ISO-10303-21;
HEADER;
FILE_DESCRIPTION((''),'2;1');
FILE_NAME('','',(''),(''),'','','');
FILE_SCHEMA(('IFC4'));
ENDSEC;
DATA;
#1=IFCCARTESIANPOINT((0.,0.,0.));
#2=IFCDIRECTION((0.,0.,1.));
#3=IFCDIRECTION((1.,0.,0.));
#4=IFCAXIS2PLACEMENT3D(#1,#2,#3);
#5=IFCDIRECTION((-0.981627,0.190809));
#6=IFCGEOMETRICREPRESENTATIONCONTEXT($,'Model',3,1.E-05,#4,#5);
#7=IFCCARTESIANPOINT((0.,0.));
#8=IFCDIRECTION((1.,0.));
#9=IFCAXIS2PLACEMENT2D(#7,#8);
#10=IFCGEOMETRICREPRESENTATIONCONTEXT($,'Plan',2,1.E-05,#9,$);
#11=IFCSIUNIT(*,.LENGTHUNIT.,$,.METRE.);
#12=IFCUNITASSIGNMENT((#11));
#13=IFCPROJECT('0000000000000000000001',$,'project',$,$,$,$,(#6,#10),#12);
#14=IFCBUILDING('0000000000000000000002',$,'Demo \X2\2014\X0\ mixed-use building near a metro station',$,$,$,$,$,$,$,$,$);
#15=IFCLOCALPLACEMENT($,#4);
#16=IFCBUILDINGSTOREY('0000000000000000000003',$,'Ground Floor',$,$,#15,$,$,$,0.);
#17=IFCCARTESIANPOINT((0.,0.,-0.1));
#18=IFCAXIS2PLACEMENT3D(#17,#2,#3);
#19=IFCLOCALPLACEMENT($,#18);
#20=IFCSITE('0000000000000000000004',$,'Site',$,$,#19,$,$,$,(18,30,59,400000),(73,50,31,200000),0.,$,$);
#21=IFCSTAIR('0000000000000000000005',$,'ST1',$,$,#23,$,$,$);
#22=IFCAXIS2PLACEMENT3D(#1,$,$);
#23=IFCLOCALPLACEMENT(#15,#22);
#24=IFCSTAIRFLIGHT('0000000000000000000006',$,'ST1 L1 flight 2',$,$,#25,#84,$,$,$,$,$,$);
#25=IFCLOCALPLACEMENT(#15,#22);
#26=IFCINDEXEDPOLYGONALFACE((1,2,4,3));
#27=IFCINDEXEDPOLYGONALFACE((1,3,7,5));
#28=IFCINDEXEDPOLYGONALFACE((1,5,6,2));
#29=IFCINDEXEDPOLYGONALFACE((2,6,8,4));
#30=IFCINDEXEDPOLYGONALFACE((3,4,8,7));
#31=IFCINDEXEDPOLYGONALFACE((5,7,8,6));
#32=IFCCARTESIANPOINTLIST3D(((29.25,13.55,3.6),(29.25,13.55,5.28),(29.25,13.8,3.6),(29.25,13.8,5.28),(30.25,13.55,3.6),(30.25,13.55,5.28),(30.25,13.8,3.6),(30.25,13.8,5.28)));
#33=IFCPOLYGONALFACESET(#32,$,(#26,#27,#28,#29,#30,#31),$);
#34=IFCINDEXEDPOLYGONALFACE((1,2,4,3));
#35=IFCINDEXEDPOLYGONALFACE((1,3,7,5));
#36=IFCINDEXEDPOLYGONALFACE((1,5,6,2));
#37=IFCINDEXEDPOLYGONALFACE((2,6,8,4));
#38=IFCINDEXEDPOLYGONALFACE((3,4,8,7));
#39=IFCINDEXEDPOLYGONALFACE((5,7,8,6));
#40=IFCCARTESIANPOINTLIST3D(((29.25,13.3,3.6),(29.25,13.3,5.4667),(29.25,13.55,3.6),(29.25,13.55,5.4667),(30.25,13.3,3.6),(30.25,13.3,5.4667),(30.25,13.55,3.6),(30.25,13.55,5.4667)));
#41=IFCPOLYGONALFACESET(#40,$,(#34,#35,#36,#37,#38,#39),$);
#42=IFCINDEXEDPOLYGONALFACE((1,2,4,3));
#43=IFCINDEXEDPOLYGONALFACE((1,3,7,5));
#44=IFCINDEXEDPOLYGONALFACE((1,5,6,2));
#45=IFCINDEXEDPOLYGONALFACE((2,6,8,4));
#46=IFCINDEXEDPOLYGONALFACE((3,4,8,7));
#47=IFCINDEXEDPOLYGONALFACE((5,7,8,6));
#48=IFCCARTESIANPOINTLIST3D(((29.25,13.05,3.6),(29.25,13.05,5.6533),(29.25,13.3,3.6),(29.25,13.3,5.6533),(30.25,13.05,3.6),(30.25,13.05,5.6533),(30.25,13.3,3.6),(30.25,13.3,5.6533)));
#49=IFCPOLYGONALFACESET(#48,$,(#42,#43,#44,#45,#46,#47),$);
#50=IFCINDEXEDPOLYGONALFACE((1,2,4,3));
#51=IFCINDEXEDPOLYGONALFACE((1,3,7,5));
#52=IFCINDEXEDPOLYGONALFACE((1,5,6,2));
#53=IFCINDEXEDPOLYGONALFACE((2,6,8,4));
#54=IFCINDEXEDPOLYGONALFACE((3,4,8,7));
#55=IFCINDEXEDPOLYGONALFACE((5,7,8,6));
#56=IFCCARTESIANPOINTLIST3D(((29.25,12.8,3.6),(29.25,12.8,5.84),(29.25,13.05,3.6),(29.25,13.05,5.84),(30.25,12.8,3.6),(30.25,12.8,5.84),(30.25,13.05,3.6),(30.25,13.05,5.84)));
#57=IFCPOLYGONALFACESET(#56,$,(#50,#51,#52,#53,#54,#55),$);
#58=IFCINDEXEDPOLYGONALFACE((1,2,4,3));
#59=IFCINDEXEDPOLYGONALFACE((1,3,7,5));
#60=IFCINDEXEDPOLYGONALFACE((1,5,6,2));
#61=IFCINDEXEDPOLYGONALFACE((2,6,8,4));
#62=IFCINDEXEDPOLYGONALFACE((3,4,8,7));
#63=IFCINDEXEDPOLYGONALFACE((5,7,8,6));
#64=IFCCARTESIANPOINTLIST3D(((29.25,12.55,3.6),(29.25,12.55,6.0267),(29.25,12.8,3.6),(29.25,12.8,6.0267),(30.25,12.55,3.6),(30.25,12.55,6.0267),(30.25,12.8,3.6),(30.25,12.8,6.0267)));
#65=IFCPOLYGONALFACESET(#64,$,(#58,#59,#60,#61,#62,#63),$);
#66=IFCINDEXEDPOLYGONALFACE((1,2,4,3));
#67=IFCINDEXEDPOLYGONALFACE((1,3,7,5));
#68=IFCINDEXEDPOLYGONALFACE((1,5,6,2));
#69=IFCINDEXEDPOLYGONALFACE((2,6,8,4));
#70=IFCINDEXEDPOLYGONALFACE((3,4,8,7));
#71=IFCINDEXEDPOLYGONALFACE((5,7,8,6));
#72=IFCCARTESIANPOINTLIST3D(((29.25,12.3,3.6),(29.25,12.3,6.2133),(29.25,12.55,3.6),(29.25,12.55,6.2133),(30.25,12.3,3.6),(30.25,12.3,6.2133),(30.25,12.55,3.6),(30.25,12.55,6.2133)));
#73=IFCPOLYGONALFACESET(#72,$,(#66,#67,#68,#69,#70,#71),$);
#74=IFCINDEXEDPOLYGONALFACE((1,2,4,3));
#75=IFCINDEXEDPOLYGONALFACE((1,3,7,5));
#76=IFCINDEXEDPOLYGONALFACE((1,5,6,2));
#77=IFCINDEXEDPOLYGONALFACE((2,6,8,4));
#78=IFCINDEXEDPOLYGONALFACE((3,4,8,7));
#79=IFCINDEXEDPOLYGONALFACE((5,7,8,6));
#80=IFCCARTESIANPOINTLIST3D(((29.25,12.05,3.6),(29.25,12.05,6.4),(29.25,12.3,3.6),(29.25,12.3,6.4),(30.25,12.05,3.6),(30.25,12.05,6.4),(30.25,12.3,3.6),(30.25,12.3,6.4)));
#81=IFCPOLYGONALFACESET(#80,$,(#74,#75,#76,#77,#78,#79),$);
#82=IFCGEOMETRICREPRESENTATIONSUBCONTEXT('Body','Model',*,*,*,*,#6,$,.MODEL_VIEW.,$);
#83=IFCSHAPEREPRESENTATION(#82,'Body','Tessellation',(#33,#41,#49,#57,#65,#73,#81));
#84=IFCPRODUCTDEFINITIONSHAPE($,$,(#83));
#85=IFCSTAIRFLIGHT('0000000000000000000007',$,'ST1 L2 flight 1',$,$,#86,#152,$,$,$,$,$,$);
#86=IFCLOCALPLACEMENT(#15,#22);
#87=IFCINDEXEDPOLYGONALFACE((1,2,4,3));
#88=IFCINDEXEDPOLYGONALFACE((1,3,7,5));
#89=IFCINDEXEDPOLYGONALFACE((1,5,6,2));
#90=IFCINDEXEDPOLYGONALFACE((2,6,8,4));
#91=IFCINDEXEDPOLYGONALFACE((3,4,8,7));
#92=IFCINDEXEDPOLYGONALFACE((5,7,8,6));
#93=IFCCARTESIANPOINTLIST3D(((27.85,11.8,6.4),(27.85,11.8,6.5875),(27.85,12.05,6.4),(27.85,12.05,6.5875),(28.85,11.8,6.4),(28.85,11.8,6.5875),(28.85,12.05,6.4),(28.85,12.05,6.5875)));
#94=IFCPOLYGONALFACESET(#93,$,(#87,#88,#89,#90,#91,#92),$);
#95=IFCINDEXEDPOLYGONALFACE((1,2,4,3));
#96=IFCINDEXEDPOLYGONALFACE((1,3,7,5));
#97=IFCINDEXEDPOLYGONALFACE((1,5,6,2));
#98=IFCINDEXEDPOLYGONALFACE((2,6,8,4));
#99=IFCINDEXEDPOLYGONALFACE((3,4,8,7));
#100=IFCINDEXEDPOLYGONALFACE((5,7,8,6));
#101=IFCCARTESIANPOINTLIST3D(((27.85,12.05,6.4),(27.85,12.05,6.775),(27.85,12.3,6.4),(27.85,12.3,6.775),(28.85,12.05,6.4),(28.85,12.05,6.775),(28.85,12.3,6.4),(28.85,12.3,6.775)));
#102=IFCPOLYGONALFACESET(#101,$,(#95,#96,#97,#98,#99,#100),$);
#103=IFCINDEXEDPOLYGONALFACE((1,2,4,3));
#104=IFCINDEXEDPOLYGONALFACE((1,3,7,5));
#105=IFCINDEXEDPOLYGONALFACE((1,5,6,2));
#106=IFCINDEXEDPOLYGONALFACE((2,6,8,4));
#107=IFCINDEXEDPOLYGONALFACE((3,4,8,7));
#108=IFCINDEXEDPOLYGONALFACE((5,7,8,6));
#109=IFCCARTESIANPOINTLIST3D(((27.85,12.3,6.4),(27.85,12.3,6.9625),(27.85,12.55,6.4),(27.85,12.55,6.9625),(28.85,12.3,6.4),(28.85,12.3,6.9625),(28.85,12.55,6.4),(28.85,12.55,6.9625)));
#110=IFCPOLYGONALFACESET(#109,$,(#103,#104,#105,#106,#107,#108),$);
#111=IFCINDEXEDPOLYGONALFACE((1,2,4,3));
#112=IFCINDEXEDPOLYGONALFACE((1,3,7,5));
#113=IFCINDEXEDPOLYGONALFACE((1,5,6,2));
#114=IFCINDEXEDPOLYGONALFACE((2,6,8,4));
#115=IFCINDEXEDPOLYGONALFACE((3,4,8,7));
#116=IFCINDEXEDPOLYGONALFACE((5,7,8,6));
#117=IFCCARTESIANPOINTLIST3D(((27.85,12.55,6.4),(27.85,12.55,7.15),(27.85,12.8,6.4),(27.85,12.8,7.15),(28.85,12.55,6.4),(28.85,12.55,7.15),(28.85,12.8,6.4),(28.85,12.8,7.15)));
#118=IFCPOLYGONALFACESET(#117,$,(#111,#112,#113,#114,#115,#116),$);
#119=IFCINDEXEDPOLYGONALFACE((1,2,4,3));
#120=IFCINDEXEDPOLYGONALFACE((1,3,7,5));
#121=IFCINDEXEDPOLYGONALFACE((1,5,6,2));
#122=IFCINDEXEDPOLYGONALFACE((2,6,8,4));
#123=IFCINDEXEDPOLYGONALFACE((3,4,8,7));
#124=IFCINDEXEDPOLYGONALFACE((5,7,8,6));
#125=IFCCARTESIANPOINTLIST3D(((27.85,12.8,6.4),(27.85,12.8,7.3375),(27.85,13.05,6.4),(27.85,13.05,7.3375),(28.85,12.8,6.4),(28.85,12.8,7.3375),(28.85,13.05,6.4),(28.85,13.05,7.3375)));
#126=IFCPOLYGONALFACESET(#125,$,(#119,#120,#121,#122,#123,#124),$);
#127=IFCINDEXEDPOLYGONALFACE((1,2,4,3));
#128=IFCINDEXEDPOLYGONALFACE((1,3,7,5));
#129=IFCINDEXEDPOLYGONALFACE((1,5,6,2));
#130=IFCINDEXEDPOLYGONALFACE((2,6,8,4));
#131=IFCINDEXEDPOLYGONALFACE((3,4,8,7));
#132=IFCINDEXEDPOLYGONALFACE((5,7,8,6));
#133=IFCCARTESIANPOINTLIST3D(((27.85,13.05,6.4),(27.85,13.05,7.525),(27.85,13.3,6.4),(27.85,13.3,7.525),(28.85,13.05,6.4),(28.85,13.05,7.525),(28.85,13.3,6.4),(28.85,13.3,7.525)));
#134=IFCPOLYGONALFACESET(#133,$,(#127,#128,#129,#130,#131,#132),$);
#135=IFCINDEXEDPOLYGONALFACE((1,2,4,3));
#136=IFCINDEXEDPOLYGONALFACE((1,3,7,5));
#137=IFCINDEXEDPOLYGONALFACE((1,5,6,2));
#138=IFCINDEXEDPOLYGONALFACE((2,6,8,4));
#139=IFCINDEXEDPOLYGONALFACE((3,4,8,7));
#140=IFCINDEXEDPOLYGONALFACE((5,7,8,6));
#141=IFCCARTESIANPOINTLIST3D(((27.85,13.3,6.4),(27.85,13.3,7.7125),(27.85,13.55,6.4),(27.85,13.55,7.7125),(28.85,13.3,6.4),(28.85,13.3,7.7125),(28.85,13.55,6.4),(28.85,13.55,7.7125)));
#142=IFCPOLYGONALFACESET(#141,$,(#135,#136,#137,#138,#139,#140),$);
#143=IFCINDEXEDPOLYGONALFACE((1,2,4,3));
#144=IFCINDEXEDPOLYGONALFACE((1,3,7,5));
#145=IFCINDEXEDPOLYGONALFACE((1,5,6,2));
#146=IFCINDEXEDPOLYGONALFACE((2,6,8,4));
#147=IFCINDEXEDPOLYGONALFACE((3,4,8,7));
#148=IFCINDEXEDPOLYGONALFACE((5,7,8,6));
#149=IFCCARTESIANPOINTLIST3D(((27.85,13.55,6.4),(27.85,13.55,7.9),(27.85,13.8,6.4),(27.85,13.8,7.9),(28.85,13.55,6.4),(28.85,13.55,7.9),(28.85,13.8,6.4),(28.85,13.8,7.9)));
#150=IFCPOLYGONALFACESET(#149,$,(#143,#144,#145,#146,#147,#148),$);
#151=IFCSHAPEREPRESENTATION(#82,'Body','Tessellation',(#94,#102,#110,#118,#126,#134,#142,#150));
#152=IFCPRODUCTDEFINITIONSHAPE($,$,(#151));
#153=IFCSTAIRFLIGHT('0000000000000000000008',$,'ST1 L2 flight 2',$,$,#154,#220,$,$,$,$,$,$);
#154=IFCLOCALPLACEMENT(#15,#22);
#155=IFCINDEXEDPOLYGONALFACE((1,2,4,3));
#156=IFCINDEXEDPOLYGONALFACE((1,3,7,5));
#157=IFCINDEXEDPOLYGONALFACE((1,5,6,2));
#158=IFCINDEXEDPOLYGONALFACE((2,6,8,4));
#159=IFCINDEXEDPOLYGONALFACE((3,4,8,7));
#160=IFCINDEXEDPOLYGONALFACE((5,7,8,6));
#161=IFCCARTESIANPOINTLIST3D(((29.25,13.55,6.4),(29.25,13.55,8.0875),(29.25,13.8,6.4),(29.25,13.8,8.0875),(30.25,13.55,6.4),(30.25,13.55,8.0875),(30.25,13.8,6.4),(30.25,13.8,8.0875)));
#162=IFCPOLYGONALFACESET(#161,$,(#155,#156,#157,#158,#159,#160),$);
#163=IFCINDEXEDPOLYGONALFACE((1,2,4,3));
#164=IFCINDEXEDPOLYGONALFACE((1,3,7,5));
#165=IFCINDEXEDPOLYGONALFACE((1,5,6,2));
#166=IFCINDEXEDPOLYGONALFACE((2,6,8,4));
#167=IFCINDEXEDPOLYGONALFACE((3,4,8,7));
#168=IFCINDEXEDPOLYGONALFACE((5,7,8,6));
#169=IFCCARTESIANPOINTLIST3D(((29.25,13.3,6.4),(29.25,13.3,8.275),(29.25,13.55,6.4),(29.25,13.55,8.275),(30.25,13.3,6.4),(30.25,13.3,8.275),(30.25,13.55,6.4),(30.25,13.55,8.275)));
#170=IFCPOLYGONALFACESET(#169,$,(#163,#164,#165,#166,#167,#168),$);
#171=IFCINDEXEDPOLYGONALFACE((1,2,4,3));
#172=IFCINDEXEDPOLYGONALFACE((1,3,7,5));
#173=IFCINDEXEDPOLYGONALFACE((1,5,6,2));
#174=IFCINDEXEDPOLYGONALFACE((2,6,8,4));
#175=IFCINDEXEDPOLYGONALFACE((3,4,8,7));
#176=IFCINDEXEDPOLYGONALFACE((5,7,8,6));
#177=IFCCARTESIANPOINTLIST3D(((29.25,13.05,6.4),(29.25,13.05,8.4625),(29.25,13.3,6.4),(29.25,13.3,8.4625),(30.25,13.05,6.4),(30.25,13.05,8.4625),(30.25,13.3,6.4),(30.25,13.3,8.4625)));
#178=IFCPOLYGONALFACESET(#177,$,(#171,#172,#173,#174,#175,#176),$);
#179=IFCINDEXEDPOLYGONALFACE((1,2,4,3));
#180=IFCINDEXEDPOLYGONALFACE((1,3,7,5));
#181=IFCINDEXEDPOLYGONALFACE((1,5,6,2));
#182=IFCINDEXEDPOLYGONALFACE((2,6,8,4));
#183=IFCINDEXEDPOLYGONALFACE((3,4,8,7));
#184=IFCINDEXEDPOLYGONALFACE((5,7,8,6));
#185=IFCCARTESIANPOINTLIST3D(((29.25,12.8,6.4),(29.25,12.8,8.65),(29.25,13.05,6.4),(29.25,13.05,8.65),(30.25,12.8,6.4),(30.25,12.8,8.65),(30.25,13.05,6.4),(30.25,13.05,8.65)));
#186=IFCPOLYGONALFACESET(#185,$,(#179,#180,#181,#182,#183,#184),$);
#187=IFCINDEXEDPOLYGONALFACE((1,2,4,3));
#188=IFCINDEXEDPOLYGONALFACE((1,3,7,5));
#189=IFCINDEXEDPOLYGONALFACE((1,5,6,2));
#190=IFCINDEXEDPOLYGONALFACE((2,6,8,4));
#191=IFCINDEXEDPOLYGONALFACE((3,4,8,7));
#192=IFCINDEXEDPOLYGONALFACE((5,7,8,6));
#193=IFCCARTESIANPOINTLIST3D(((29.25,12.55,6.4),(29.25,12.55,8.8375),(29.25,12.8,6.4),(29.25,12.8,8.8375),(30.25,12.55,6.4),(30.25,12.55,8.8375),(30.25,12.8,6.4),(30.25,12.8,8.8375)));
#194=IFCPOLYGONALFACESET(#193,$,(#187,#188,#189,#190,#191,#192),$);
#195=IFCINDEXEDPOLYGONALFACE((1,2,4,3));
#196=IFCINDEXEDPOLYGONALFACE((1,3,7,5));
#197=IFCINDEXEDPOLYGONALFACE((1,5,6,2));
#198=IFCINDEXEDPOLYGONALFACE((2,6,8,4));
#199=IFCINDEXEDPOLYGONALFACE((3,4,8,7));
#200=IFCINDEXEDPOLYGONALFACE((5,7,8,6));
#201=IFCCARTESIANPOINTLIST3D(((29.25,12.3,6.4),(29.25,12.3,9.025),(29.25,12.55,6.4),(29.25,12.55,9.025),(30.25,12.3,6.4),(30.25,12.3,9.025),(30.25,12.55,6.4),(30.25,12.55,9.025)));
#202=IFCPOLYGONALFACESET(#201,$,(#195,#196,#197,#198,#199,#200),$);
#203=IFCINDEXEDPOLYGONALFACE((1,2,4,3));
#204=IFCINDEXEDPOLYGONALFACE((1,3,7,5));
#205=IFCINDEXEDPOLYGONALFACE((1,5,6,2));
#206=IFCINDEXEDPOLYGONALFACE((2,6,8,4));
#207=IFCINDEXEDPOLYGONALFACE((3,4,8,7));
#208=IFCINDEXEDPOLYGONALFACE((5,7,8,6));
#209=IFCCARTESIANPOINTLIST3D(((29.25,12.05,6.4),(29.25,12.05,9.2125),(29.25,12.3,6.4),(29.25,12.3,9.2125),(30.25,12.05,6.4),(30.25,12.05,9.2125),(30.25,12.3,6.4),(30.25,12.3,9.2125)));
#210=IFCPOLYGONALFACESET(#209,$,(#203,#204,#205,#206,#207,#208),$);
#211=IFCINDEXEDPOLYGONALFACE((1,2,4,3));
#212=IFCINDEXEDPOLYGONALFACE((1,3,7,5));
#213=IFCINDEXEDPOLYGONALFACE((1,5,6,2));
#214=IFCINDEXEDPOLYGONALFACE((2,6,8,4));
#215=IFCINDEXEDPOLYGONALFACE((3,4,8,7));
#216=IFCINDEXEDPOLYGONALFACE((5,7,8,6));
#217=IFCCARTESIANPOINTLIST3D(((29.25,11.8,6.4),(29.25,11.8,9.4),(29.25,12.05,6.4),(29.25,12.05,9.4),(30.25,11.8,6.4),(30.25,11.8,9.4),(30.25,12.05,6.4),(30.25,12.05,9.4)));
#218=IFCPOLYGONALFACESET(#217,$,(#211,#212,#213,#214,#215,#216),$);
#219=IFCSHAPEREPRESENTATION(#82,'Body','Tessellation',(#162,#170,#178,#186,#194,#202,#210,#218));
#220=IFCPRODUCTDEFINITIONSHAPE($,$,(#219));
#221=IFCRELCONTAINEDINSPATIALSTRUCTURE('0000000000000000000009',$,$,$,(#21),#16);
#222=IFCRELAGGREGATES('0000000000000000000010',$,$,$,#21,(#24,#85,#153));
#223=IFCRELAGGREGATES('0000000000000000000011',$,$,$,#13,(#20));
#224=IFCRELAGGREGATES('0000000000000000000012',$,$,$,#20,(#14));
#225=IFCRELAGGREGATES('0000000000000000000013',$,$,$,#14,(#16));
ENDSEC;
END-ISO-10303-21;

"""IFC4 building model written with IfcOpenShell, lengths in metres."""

from ifc_helpers import new_model, si_unit, direction, frame, origin_with_axes, origin_2d_with_axis, place, context, subcontext, project, spatial, line, indexed_curve, outline, extrude, element, aggregate, save


model = new_model("IFC4")

# Units and contexts
model_context = context("Model", 3, precision=1e-05, world=origin_with_axes(), true_north=direction((-0.981627, 0.190809)))
plan_context = context("Plan", 2, precision=1e-05, world=origin_2d_with_axis())
body_context = subcontext(model_context, "Body", "Model", "MODEL_VIEW")
ifc_project = project(units=[si_unit("LENGTHUNIT", "METRE")], contexts=[model_context, plan_context])

# Site, building, storey
site_placement = place(None, frame((0.0, 0.0, -0.1), z_axis=(0.0, 0.0, 1.0), x_axis=(1.0, 0.0, 0.0)))
site = spatial("IfcSite", under=ifc_project, at=site_placement, Name="Site", RefLatitude=(18, 30, 59, 400000), RefLongitude=(73, 50, 31, 200000), RefElevation=0.0)
building = spatial("IfcBuilding", under=site, Name="Demo — mixed-use building near a metro station")
storey_placement = place(None, origin_with_axes())
storey = spatial("IfcBuildingStorey", under=building, at=storey_placement, Name="Ground Floor", Elevation=0.0)

# Stair, stair flights
stair = element("IfcStair", 1, inside=storey, Name="ST1")
stair_flight_1_placement = place(None, origin_with_axes())
stair_flight_1 = element("IfcStairFlight", 2, at=stair_flight_1_placement, Name="ST1 L1 flight 2", context=body_context, shape_type="SweptSolid", body=[
    extrude(outline(indexed_curve([(29.25, 13.55), (30.25, 13.55), (30.25, 13.8), (29.25, 13.8)], segments=[line(1, 2, 3, 4, 1)])), frame((0.0, 0.0, 3.6), z_axis=(0.0, 0.0, 1.0), x_axis=(1.0, 0.0, 0.0)), (0.0, 0.0, 1.0), 1.68),
    extrude(outline(indexed_curve([(29.25, 13.3), (30.25, 13.3), (30.25, 13.55), (29.25, 13.55)], segments=[line(1, 2, 3, 4, 1)])), frame((0.0, 0.0, 3.6), z_axis=(0.0, 0.0, 1.0), x_axis=(1.0, 0.0, 0.0)), (0.0, 0.0, 1.0), 1.8667),
    extrude(outline(indexed_curve([(29.25, 13.05), (30.25, 13.05), (30.25, 13.3), (29.25, 13.3)], segments=[line(1, 2, 3, 4, 1)])), frame((0.0, 0.0, 3.6), z_axis=(0.0, 0.0, 1.0), x_axis=(1.0, 0.0, 0.0)), (0.0, 0.0, 1.0), 2.0533),
    extrude(outline(indexed_curve([(29.25, 12.8), (30.25, 12.8), (30.25, 13.05), (29.25, 13.05)], segments=[line(1, 2, 3, 4, 1)])), frame((0.0, 0.0, 3.6), z_axis=(0.0, 0.0, 1.0), x_axis=(1.0, 0.0, 0.0)), (0.0, 0.0, 1.0), 2.24),
    extrude(outline(indexed_curve([(29.25, 12.55), (30.25, 12.55), (30.25, 12.8), (29.25, 12.8)], segments=[line(1, 2, 3, 4, 1)])), frame((0.0, 0.0, 3.6), z_axis=(0.0, 0.0, 1.0), x_axis=(1.0, 0.0, 0.0)), (0.0, 0.0, 1.0), 2.4267),
    extrude(outline(indexed_curve([(29.25, 12.3), (30.25, 12.3), (30.25, 12.55), (29.25, 12.55)], segments=[line(1, 2, 3, 4, 1)])), frame((0.0, 0.0, 3.6), z_axis=(0.0, 0.0, 1.0), x_axis=(1.0, 0.0, 0.0)), (0.0, 0.0, 1.0), 2.6133),
    extrude(outline(indexed_curve([(29.25, 12.05), (30.25, 12.05), (30.25, 12.3), (29.25, 12.3)], segments=[line(1, 2, 3, 4, 1)])), frame((0.0, 0.0, 3.6), z_axis=(0.0, 0.0, 1.0), x_axis=(1.0, 0.0, 0.0)), (0.0, 0.0, 1.0), 2.8),
])
stair_flight_2_placement = place(None, origin_with_axes())
stair_flight_2 = element("IfcStairFlight", 3, at=stair_flight_2_placement, Name="ST1 L2 flight 1", context=body_context, shape_type="SweptSolid", body=[
    extrude(outline(indexed_curve([(27.85, 11.8), (28.85, 11.8), (28.85, 12.05), (27.85, 12.05)], segments=[line(1, 2, 3, 4, 1)])), frame((0.0, 0.0, 6.4), z_axis=(0.0, 0.0, 1.0), x_axis=(1.0, 0.0, 0.0)), (0.0, 0.0, 1.0), 0.1875),
    extrude(outline(indexed_curve([(27.85, 12.05), (28.85, 12.05), (28.85, 12.3), (27.85, 12.3)], segments=[line(1, 2, 3, 4, 1)])), frame((0.0, 0.0, 6.4), z_axis=(0.0, 0.0, 1.0), x_axis=(1.0, 0.0, 0.0)), (0.0, 0.0, 1.0), 0.375),
    extrude(outline(indexed_curve([(27.85, 12.3), (28.85, 12.3), (28.85, 12.55), (27.85, 12.55)], segments=[line(1, 2, 3, 4, 1)])), frame((0.0, 0.0, 6.4), z_axis=(0.0, 0.0, 1.0), x_axis=(1.0, 0.0, 0.0)), (0.0, 0.0, 1.0), 0.5625),
    extrude(outline(indexed_curve([(27.85, 12.55), (28.85, 12.55), (28.85, 12.8), (27.85, 12.8)], segments=[line(1, 2, 3, 4, 1)])), frame((0.0, 0.0, 6.4), z_axis=(0.0, 0.0, 1.0), x_axis=(1.0, 0.0, 0.0)), (0.0, 0.0, 1.0), 0.75),
    extrude(outline(indexed_curve([(27.85, 12.8), (28.85, 12.8), (28.85, 13.05), (27.85, 13.05)], segments=[line(1, 2, 3, 4, 1)])), frame((0.0, 0.0, 6.4), z_axis=(0.0, 0.0, 1.0), x_axis=(1.0, 0.0, 0.0)), (0.0, 0.0, 1.0), 0.9375),
    extrude(outline(indexed_curve([(27.85, 13.05), (28.85, 13.05), (28.85, 13.3), (27.85, 13.3)], segments=[line(1, 2, 3, 4, 1)])), frame((0.0, 0.0, 6.4), z_axis=(0.0, 0.0, 1.0), x_axis=(1.0, 0.0, 0.0)), (0.0, 0.0, 1.0), 1.125),
    extrude(outline(indexed_curve([(27.85, 13.3), (28.85, 13.3), (28.85, 13.55), (27.85, 13.55)], segments=[line(1, 2, 3, 4, 1)])), frame((0.0, 0.0, 6.4), z_axis=(0.0, 0.0, 1.0), x_axis=(1.0, 0.0, 0.0)), (0.0, 0.0, 1.0), 1.3125),
    extrude(outline(indexed_curve([(27.85, 13.55), (28.85, 13.55), (28.85, 13.8), (27.85, 13.8)], segments=[line(1, 2, 3, 4, 1)])), frame((0.0, 0.0, 6.4), z_axis=(0.0, 0.0, 1.0), x_axis=(1.0, 0.0, 0.0)), (0.0, 0.0, 1.0), 1.5),
])
stair_flight_3_placement = place(None, origin_with_axes())
stair_flight_3 = element("IfcStairFlight", 4, at=stair_flight_3_placement, Name="ST1 L2 flight 2", context=body_context, shape_type="SweptSolid", body=[
    extrude(outline(indexed_curve([(29.25, 13.55), (30.25, 13.55), (30.25, 13.8), (29.25, 13.8)], segments=[line(1, 2, 3, 4, 1)])), frame((0.0, 0.0, 6.4), z_axis=(0.0, 0.0, 1.0), x_axis=(1.0, 0.0, 0.0)), (0.0, 0.0, 1.0), 1.6875),
    extrude(outline(indexed_curve([(29.25, 13.3), (30.25, 13.3), (30.25, 13.55), (29.25, 13.55)], segments=[line(1, 2, 3, 4, 1)])), frame((0.0, 0.0, 6.4), z_axis=(0.0, 0.0, 1.0), x_axis=(1.0, 0.0, 0.0)), (0.0, 0.0, 1.0), 1.875),
    extrude(outline(indexed_curve([(29.25, 13.05), (30.25, 13.05), (30.25, 13.3), (29.25, 13.3)], segments=[line(1, 2, 3, 4, 1)])), frame((0.0, 0.0, 6.4), z_axis=(0.0, 0.0, 1.0), x_axis=(1.0, 0.0, 0.0)), (0.0, 0.0, 1.0), 2.0625),
    extrude(outline(indexed_curve([(29.25, 12.8), (30.25, 12.8), (30.25, 13.05), (29.25, 13.05)], segments=[line(1, 2, 3, 4, 1)])), frame((0.0, 0.0, 6.4), z_axis=(0.0, 0.0, 1.0), x_axis=(1.0, 0.0, 0.0)), (0.0, 0.0, 1.0), 2.25),
    extrude(outline(indexed_curve([(29.25, 12.55), (30.25, 12.55), (30.25, 12.8), (29.25, 12.8)], segments=[line(1, 2, 3, 4, 1)])), frame((0.0, 0.0, 6.4), z_axis=(0.0, 0.0, 1.0), x_axis=(1.0, 0.0, 0.0)), (0.0, 0.0, 1.0), 2.4375),
    extrude(outline(indexed_curve([(29.25, 12.3), (30.25, 12.3), (30.25, 12.55), (29.25, 12.55)], segments=[line(1, 2, 3, 4, 1)])), frame((0.0, 0.0, 6.4), z_axis=(0.0, 0.0, 1.0), x_axis=(1.0, 0.0, 0.0)), (0.0, 0.0, 1.0), 2.625),
    extrude(outline(indexed_curve([(29.25, 12.05), (30.25, 12.05), (30.25, 12.3), (29.25, 12.3)], segments=[line(1, 2, 3, 4, 1)])), frame((0.0, 0.0, 6.4), z_axis=(0.0, 0.0, 1.0), x_axis=(1.0, 0.0, 0.0)), (0.0, 0.0, 1.0), 2.8125),
    extrude(outline(indexed_curve([(29.25, 11.8), (30.25, 11.8), (30.25, 12.05), (29.25, 12.05)], segments=[line(1, 2, 3, 4, 1)])), frame((0.0, 0.0, 6.4), z_axis=(0.0, 0.0, 1.0), x_axis=(1.0, 0.0, 0.0)), (0.0, 0.0, 1.0), 3.0),
])
aggregate(stair, [stair_flight_1, stair_flight_2, stair_flight_3])

save(model, "model.ifc")
